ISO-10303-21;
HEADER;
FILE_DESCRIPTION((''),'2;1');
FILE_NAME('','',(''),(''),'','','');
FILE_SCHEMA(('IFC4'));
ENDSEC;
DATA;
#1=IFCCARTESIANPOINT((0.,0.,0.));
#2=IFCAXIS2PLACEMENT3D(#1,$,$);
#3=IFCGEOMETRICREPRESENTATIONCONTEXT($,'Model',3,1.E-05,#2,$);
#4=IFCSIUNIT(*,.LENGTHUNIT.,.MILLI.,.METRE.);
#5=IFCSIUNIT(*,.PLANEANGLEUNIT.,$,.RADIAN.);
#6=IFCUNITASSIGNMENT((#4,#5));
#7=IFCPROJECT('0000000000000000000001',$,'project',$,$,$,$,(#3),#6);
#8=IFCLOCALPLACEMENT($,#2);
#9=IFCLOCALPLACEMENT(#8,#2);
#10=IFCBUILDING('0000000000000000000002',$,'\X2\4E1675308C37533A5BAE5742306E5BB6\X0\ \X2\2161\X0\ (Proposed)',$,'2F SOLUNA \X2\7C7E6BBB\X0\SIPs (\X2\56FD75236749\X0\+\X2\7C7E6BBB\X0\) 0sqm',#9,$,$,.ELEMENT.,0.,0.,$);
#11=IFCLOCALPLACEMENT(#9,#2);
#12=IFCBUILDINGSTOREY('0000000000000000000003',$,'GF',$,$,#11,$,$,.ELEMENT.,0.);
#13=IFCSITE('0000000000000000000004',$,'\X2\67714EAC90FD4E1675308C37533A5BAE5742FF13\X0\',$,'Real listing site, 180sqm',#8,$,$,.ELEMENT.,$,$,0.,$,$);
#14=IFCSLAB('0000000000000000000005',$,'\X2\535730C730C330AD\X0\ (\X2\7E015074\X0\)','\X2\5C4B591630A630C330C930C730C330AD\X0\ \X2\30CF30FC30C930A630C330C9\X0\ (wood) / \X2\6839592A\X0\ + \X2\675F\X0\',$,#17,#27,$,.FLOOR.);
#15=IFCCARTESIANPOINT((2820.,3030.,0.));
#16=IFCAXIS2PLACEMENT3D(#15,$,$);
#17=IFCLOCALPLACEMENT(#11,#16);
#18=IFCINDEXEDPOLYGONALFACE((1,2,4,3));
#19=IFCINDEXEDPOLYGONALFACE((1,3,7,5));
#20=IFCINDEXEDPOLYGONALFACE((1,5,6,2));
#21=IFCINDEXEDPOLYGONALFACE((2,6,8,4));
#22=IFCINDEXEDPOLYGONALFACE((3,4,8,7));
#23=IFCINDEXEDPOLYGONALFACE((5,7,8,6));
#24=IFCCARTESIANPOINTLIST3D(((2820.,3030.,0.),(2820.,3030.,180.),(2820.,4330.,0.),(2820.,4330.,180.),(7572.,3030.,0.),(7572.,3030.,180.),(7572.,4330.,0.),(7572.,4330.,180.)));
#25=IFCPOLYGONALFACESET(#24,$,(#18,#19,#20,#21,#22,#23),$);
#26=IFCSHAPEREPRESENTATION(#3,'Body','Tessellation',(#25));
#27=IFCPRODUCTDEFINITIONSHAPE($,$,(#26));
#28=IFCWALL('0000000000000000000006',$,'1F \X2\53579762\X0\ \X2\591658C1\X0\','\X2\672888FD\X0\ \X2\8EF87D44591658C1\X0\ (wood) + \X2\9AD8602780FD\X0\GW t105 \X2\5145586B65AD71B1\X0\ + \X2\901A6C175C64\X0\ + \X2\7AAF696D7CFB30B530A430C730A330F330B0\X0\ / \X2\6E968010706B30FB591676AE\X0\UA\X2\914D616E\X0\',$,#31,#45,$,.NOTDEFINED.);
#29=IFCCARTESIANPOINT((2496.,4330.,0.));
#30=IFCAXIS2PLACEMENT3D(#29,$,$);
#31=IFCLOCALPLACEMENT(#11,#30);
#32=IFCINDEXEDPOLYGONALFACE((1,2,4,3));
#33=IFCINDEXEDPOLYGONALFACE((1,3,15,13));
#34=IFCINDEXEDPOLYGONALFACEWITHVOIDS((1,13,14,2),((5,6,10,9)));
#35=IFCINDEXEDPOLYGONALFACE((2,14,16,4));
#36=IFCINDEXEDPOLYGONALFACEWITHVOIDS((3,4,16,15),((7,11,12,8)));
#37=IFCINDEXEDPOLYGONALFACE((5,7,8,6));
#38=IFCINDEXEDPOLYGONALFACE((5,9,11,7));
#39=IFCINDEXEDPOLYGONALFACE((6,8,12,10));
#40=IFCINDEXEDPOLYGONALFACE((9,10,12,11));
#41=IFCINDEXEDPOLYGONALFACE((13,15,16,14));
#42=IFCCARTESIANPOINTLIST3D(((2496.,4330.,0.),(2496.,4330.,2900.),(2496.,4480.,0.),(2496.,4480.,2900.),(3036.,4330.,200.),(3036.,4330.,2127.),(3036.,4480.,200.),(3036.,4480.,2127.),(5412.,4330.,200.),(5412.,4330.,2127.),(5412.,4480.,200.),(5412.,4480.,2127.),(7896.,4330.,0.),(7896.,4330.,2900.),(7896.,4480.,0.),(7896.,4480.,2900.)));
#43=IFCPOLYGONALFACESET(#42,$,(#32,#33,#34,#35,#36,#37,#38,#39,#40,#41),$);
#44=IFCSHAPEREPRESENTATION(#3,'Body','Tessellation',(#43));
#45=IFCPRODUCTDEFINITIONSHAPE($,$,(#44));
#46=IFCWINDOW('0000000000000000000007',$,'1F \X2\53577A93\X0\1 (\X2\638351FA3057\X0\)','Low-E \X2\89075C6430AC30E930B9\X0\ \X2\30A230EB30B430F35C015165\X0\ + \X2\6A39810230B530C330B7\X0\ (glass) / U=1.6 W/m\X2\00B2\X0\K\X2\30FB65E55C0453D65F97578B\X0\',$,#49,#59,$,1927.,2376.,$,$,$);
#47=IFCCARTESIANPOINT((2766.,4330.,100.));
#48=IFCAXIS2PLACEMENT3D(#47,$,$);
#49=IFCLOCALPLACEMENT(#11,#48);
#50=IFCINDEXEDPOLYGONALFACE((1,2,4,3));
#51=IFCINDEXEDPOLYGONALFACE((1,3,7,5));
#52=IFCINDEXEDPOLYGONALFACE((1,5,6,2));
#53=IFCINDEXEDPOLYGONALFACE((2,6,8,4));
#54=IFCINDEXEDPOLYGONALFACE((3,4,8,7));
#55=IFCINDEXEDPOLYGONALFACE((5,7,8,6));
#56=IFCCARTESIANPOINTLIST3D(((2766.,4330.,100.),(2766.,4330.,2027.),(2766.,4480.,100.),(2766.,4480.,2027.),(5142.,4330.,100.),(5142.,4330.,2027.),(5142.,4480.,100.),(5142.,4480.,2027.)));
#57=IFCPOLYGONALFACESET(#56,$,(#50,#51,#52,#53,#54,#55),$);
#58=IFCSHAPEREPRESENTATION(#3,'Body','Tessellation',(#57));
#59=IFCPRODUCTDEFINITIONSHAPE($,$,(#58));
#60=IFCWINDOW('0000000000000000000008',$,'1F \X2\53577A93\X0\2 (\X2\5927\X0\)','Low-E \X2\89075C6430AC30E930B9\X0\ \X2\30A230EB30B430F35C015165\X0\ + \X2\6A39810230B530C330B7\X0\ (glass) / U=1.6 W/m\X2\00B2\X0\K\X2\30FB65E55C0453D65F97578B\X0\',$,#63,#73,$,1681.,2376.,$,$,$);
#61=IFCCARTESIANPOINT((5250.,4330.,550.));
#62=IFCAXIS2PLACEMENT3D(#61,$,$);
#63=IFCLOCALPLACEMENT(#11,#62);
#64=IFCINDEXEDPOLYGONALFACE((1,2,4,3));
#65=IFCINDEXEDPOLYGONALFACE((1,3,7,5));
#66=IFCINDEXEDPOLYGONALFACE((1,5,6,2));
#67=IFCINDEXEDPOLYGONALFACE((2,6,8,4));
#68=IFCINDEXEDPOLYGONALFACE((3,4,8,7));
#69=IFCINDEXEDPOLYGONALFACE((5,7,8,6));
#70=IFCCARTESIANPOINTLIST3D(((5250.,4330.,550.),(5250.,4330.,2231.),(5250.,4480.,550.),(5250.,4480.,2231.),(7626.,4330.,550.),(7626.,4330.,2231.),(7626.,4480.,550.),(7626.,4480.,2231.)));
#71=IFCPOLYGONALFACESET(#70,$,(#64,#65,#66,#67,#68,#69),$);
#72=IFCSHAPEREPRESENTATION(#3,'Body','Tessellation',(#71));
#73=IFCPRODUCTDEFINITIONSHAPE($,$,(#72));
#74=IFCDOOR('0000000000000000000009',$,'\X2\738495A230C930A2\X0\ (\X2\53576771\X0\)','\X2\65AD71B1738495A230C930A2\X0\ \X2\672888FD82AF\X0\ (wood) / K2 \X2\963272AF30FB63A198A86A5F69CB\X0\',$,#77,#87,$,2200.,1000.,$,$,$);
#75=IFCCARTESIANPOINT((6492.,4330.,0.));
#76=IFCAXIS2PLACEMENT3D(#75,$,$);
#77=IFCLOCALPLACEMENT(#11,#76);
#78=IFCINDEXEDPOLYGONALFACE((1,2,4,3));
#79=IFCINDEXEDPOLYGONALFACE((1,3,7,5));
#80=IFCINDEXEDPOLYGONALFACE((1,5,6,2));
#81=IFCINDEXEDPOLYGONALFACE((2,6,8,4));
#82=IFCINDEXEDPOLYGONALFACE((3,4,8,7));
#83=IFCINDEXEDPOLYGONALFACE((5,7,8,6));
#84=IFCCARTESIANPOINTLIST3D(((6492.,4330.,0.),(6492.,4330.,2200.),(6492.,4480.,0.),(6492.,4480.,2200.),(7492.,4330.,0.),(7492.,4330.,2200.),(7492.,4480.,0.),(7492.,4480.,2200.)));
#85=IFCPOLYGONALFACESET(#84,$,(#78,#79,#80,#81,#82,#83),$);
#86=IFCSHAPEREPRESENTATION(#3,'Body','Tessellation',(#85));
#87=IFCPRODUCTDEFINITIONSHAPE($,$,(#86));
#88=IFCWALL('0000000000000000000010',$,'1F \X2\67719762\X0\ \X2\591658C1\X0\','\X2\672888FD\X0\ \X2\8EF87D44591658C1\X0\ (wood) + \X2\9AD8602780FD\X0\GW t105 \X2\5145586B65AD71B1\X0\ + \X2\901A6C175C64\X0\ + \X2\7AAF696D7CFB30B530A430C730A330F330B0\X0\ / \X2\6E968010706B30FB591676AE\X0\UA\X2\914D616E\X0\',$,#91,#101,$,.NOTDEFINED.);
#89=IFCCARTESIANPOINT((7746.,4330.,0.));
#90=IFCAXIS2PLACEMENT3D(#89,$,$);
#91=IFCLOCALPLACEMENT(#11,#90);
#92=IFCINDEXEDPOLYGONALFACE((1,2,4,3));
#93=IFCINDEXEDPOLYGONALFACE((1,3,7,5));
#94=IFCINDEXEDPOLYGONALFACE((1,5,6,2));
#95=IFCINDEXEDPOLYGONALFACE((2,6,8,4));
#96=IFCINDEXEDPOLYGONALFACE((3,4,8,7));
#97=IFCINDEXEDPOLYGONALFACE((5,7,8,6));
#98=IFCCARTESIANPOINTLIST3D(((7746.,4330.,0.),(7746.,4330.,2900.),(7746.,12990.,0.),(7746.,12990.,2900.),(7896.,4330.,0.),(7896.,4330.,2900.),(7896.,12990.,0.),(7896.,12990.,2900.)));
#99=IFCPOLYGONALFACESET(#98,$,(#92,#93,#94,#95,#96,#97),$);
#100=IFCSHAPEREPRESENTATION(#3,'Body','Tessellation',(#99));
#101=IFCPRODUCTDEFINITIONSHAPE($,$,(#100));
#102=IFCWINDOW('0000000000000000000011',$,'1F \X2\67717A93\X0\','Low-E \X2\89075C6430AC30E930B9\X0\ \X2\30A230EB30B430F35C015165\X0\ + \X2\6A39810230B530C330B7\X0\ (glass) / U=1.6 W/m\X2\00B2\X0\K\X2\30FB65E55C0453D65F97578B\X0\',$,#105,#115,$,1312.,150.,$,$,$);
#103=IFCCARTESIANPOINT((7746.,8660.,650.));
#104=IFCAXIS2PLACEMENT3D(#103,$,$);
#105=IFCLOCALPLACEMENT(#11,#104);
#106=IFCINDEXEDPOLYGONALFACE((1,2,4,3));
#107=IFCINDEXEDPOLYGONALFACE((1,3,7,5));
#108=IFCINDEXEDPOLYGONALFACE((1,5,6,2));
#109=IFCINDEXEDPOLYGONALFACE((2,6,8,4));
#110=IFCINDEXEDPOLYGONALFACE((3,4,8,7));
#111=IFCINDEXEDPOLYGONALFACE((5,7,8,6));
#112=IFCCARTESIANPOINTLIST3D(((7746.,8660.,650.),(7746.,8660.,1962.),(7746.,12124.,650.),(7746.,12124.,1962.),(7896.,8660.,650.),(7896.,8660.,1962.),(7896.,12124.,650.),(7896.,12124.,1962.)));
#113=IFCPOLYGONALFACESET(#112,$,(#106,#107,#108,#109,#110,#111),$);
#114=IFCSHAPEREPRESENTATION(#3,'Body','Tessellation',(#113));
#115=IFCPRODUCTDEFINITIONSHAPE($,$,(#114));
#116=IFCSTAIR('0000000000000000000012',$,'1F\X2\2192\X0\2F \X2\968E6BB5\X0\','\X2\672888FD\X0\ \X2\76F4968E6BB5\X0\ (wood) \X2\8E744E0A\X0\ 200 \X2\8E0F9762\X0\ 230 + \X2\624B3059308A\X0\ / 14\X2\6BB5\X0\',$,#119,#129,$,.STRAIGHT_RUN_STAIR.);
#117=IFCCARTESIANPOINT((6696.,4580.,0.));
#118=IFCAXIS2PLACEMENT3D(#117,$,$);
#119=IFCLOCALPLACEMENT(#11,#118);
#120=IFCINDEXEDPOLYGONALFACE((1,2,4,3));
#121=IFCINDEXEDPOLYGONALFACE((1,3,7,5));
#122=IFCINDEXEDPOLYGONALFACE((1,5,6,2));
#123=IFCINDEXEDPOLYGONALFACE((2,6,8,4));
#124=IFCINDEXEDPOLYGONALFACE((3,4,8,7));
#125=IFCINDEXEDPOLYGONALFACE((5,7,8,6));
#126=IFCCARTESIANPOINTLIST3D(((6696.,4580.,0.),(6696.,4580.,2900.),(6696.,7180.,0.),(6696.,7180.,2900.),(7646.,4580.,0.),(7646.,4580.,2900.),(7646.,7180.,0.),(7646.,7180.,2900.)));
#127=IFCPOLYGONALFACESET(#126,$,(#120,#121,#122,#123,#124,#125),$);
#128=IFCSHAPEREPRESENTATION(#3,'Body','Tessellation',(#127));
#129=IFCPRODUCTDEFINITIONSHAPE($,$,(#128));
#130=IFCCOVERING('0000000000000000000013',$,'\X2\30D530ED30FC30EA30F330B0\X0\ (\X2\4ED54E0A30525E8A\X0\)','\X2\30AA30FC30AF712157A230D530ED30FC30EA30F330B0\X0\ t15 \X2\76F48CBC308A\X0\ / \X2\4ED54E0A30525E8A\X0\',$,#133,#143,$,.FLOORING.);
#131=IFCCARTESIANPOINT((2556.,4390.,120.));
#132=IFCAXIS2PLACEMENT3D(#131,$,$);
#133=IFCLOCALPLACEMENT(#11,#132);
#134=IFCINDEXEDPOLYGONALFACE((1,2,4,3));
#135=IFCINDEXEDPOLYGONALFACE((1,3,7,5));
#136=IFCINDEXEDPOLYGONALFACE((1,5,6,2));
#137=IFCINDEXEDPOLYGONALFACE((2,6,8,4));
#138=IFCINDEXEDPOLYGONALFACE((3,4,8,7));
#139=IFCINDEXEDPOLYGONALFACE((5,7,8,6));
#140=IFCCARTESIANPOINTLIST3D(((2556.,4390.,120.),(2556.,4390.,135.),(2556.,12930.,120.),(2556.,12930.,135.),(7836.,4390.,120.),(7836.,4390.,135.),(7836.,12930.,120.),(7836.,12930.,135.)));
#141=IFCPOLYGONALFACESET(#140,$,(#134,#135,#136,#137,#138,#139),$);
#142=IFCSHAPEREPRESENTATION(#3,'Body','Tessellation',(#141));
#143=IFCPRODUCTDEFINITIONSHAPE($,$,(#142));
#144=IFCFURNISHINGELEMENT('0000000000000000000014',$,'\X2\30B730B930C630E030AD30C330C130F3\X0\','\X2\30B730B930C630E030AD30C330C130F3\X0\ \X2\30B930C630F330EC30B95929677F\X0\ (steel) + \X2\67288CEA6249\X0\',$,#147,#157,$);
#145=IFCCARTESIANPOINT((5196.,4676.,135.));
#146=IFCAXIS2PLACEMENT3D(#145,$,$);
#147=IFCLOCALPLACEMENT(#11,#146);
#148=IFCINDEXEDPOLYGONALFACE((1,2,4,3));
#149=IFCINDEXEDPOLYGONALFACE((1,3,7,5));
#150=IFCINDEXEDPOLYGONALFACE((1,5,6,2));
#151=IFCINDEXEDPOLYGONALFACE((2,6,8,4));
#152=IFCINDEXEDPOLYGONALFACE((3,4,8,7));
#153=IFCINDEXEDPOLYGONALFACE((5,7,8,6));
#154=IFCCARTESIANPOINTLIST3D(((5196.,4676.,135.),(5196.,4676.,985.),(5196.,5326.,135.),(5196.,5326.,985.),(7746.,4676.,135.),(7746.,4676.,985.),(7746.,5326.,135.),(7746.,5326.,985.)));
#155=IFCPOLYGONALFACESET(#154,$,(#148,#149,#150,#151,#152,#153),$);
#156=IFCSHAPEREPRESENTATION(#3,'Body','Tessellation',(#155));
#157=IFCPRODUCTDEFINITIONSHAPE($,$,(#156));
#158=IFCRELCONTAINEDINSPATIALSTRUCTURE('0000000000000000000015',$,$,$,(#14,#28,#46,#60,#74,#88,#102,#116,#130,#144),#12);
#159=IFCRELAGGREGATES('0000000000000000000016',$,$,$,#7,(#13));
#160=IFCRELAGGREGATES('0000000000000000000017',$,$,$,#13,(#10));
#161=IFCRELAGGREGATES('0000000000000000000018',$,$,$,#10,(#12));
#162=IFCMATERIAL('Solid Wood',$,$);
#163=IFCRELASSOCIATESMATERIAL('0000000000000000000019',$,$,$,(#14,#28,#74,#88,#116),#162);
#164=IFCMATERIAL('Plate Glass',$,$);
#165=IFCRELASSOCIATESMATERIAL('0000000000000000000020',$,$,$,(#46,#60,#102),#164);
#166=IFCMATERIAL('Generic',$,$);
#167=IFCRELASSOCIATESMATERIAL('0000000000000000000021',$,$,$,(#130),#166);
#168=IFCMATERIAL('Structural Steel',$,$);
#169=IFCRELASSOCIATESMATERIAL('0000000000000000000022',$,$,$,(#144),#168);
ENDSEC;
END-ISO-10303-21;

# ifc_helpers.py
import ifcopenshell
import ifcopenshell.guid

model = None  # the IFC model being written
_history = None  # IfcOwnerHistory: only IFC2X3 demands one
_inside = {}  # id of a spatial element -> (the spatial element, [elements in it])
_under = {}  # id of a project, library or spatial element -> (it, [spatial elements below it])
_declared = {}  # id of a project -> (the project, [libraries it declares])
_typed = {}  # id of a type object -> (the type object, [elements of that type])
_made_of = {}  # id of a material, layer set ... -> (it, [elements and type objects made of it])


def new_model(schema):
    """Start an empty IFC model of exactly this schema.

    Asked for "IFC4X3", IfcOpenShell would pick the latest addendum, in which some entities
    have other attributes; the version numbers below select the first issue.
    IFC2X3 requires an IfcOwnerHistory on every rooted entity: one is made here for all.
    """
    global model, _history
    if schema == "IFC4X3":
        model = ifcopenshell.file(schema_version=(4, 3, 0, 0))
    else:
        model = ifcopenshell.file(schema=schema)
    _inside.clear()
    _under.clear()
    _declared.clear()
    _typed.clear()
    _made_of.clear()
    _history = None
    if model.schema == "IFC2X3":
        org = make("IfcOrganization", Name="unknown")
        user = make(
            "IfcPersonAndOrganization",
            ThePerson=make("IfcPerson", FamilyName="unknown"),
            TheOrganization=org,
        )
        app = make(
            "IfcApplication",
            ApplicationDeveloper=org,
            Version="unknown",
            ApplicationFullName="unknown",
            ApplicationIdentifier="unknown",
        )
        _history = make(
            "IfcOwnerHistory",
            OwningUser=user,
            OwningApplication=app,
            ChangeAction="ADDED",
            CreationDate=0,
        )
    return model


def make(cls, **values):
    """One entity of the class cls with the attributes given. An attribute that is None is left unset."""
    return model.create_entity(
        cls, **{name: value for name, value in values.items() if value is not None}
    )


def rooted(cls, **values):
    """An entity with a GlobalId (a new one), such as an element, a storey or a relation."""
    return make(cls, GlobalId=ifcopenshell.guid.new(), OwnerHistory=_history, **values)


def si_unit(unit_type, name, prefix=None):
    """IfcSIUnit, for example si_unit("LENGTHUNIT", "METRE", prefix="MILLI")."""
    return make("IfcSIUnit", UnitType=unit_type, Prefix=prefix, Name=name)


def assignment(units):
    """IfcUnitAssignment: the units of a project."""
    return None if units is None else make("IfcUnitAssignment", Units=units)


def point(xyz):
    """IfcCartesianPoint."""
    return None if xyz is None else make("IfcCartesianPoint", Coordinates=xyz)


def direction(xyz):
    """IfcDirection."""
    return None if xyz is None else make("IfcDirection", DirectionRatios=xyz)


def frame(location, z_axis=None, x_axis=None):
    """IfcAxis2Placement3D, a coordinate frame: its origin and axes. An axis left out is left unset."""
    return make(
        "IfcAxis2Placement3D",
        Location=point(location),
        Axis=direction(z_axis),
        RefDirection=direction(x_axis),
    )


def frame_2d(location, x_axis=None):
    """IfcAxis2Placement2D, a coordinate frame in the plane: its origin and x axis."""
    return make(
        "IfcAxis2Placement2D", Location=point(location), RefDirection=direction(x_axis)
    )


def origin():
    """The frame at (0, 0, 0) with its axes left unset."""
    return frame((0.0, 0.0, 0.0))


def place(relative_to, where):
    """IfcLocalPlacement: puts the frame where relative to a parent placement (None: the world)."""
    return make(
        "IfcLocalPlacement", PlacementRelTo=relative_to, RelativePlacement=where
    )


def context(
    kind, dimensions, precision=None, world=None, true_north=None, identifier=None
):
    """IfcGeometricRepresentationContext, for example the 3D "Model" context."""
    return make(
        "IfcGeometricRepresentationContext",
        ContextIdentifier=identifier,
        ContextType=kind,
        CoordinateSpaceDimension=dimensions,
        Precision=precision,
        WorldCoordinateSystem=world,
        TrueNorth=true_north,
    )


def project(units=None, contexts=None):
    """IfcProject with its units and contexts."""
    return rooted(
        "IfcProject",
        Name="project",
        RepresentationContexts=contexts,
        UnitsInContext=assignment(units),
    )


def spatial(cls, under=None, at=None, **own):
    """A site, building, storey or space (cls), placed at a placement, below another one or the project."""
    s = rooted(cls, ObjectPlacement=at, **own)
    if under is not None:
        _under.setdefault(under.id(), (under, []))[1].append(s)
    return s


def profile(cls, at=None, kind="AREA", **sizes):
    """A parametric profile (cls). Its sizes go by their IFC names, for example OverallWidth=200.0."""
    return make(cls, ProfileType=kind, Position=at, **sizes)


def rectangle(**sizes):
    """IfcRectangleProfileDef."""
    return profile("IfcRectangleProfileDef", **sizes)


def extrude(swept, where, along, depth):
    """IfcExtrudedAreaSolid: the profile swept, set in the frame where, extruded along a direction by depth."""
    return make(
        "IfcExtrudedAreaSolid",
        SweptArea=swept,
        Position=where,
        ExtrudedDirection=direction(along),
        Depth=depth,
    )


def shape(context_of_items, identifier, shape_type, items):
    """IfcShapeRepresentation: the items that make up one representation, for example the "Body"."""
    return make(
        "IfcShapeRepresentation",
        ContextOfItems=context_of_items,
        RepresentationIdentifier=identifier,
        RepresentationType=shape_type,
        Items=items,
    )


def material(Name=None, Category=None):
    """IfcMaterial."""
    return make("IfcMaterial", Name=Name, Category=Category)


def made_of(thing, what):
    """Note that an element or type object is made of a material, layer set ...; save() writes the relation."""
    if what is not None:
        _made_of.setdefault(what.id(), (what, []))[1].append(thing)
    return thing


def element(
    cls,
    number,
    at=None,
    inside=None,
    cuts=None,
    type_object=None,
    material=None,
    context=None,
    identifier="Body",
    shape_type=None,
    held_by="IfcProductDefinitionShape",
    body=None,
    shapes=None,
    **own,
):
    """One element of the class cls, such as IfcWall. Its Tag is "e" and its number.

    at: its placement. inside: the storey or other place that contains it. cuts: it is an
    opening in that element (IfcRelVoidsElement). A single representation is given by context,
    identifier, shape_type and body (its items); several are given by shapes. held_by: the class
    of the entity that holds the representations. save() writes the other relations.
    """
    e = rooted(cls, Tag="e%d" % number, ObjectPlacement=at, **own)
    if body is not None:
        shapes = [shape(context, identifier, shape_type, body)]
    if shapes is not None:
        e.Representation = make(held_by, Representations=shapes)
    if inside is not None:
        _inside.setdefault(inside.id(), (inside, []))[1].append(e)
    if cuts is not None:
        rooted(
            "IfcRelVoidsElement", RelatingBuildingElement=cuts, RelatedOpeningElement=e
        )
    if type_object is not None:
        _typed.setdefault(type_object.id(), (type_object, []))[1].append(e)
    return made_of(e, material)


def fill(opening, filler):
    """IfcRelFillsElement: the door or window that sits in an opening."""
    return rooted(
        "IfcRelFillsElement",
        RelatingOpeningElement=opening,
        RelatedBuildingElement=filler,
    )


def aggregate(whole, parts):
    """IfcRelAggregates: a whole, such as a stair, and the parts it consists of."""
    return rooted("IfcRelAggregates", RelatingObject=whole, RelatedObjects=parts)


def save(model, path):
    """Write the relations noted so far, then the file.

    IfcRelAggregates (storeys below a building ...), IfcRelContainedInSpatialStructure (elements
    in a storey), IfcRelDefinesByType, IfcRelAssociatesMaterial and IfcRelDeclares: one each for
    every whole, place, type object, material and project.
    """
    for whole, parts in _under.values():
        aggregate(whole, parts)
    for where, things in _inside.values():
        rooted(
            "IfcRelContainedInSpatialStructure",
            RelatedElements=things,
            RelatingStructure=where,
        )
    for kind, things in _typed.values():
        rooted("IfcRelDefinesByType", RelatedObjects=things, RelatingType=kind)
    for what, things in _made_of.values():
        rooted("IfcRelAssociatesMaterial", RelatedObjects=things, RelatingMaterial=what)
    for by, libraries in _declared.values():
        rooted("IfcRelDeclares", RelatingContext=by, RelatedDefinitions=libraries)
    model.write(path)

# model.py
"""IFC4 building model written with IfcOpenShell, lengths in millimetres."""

from ifc_helpers import new_model, si_unit, frame, frame_2d, origin, place, context, project, spatial, rectangle, extrude, material, element, fill, save


model = new_model("IFC4")

# Units and contexts
model_context = context("Model", 3, precision=1e-05, world=origin())
ifc_project = project(units=[si_unit("LENGTHUNIT", "METRE", prefix="MILLI"), si_unit("PLANEANGLEUNIT", "RADIAN")], contexts=[model_context])

# Site, building, storey
site_placement = place(None, origin())
site = spatial("IfcSite", under=ifc_project, at=site_placement, Name="東京都世田谷区宮坂３", ObjectType="Real listing site, 180sqm", CompositionType="ELEMENT", RefElevation=0.0)
building_placement = place(site_placement, origin())
building = spatial("IfcBuilding", under=site, at=building_placement, Name="世田谷区宮坂の家 Ⅱ (Proposed)", ObjectType="2F SOLUNA 籾殻SIPs (国産杉+籾殻) 0sqm", CompositionType="ELEMENT", ElevationOfRefHeight=0.0, ElevationOfTerrain=0.0)
storey_placement = place(building_placement, origin())
storey = spatial("IfcBuildingStorey", under=building, at=storey_placement, Name="GF", CompositionType="ELEMENT", Elevation=0.0)

# Slab
ifc_material_1 = material(Name="Solid Wood")
slab_1_placement = place(storey_placement, frame((2820.0, 3030.0, 0.0)))
element("IfcSlab", 1, at=slab_1_placement, inside=storey, material=ifc_material_1, Name="南デッキ (縁側)", Description="屋外ウッドデッキ ハードウッド (wood) / 根太 + 束", PredefinedType="FLOOR", context=model_context, shape_type="SweptSolid", body=[
    extrude(rectangle(XDim=4752.0, YDim=1300.0, at=frame_2d((2376.0, 650.0))), frame((2820.0, 3030.0, 0.0)), (0.0, 0.0, 1.0), 180.0),
])

# Wall, openings, windows, door
wall_1_placement = place(storey_placement, frame((2496.0, 4330.0, 0.0)))
wall_1 = element("IfcWall", 2, at=wall_1_placement, inside=storey, material=ifc_material_1, Name="1F 南面 外壁", Description="木製 軸組外壁 (wood) + 高性能GW t105 充填断熱 + 通気層 + 窯業系サイディング / 準耐火・外皮UA配慮", PredefinedType="NOTDEFINED", context=model_context, shape_type="SweptSolid", body=[
    extrude(rectangle(XDim=5400.0, YDim=150.0, at=frame_2d((2700.0, 75.0))), frame((2496.0, 4330.0, 0.0)), (0.0, 0.0, 1.0), 2900.0),
])
opening_1_placement = place(storey_placement, frame((2766.0, 4330.0, 100.0)))
opening_1 = element("IfcOpeningElement", 3, at=opening_1_placement, cuts=wall_1, PredefinedType="NOTDEFINED", context=model_context, shape_type="SweptSolid", body=[
    extrude(rectangle(XDim=2376.0, YDim=150.0, at=frame_2d((1188.0, 75.0))), frame((2766.0, 4330.0, 100.0)), (0.0, 0.0, 1.0), 1927.0),
])
opening_2_placement = place(storey_placement, frame((5250.0, 4330.0, 550.0)))
opening_2 = element("IfcOpeningElement", 4, at=opening_2_placement, cuts=wall_1, PredefinedType="NOTDEFINED", context=model_context, shape_type="SweptSolid", body=[
    extrude(rectangle(XDim=2376.0, YDim=150.0, at=frame_2d((1188.0, 75.0))), frame((5250.0, 4330.0, 550.0)), (0.0, 0.0, 1.0), 1681.0),
])
opening_3_placement = place(storey_placement, frame((6492.0, 4330.0, 0.0)))
opening_3 = element("IfcOpeningElement", 5, at=opening_3_placement, cuts=wall_1, PredefinedType="NOTDEFINED", context=model_context, shape_type="SweptSolid", body=[
    extrude(rectangle(XDim=1000.0, YDim=150.0, at=frame_2d((500.0, 75.0))), frame((6492.0, 4330.0, 0.0)), (0.0, 0.0, 1.0), 2200.0),
])
ifc_material_2 = material(Name="Plate Glass")
window_1_placement = place(storey_placement, frame((2766.0, 4330.0, 100.0)))
window_1 = element("IfcWindow", 6, at=window_1_placement, inside=storey, material=ifc_material_2, Name="1F 南窓1 (掃出し)", Description="Low-E 複層ガラス アルゴン封入 + 樹脂サッシ (glass) / U=1.6 W/m²K・日射取得型", OverallHeight=1927.0, OverallWidth=2376.0, context=model_context, shape_type="SweptSolid", body=[
    extrude(rectangle(XDim=2376.0, YDim=150.0, at=frame_2d((1188.0, 75.0))), frame((2766.0, 4330.0, 100.0)), (0.0, 0.0, 1.0), 1927.0),
])
fill(opening_1, window_1)
window_2_placement = place(storey_placement, frame((5250.0, 4330.0, 550.0)))
window_2 = element("IfcWindow", 7, at=window_2_placement, inside=storey, material=ifc_material_2, Name="1F 南窓2 (大)", Description="Low-E 複層ガラス アルゴン封入 + 樹脂サッシ (glass) / U=1.6 W/m²K・日射取得型", OverallHeight=1681.0, OverallWidth=2376.0, context=model_context, shape_type="SweptSolid", body=[
    extrude(rectangle(XDim=2376.0, YDim=150.0, at=frame_2d((1188.0, 75.0))), frame((5250.0, 4330.0, 550.0)), (0.0, 0.0, 1.0), 1681.0),
])
fill(opening_2, window_2)
door_placement = place(storey_placement, frame((6492.0, 4330.0, 0.0)))
door = element("IfcDoor", 8, at=door_placement, inside=storey, material=ifc_material_1, Name="玄関ドア (南東)", Description="断熱玄関ドア 木製芯 (wood) / K2 防犯・採風機構", OverallHeight=2200.0, OverallWidth=1000.0, context=model_context, shape_type="SweptSolid", body=[
    extrude(rectangle(XDim=1000.0, YDim=150.0, at=frame_2d((500.0, 75.0))), frame((6492.0, 4330.0, 0.0)), (0.0, 0.0, 1.0), 2200.0),
])
fill(opening_3, door)

# Wall, opening, window
wall_2_placement = place(storey_placement, frame((7746.0, 4330.0, 0.0)))
wall_2 = element("IfcWall", 9, at=wall_2_placement, inside=storey, material=ifc_material_1, Name="1F 東面 外壁", Description="木製 軸組外壁 (wood) + 高性能GW t105 充填断熱 + 通気層 + 窯業系サイディング / 準耐火・外皮UA配慮", PredefinedType="NOTDEFINED", context=model_context, shape_type="SweptSolid", body=[
    extrude(rectangle(XDim=150.0, YDim=8660.0, at=frame_2d((75.0, 4330.0))), frame((7746.0, 4330.0, 0.0)), (0.0, 0.0, 1.0), 2900.0),
])
opening_4_placement = place(storey_placement, frame((7746.0, 8660.0, 650.0)))
opening_4 = element("IfcOpeningElement", 10, at=opening_4_placement, cuts=wall_2, PredefinedType="NOTDEFINED", context=model_context, shape_type="SweptSolid", body=[
    extrude(rectangle(XDim=150.0, YDim=3464.0, at=frame_2d((75.0, 1732.0))), frame((7746.0, 8660.0, 650.0)), (0.0, 0.0, 1.0), 1312.0),
])
window_3_placement = place(storey_placement, frame((7746.0, 8660.0, 650.0)))
window_3 = element("IfcWindow", 11, at=window_3_placement, inside=storey, material=ifc_material_2, Name="1F 東窓", Description="Low-E 複層ガラス アルゴン封入 + 樹脂サッシ (glass) / U=1.6 W/m²K・日射取得型", OverallHeight=1312.0, OverallWidth=150.0, context=model_context, shape_type="SweptSolid", body=[
    extrude(rectangle(XDim=150.0, YDim=3464.0, at=frame_2d((75.0, 1732.0))), frame((7746.0, 8660.0, 650.0)), (0.0, 0.0, 1.0), 1312.0),
])
fill(opening_4, window_3)

# Stair
stair_placement = place(storey_placement, frame((6696.0, 4580.0, 0.0)))
element("IfcStair", 12, at=stair_placement, inside=storey, material=ifc_material_1, Name="1F→2F 階段", Description="木製 直階段 (wood) 蹴上 200 踏面 230 + 手すり / 14段", PredefinedType="STRAIGHT_RUN_STAIR", context=model_context, shape_type="SweptSolid", body=[
    extrude(rectangle(XDim=950.0, YDim=2600.0, at=frame_2d((475.0, 1300.0))), frame((6696.0, 4580.0, 0.0)), (0.0, 0.0, 1.0), 2900.0),
])

# Covering
ifc_material_3 = material(Name="Generic")
covering_placement = place(storey_placement, frame((2556.0, 4390.0, 120.0)))
element("IfcCovering", 13, at=covering_placement, inside=storey, material=ifc_material_3, Name="フローリング (仕上げ床)", Description="オーク無垢フローリング t15 直貼り / 仕上げ床", PredefinedType="FLOORING", context=model_context, shape_type="SweptSolid", body=[
    extrude(rectangle(XDim=5280.0, YDim=8540.0, at=frame_2d((2640.0, 4270.0))), frame((2556.0, 4390.0, 120.0)), (0.0, 0.0, 1.0), 15.0),
])

# Furnishing element
ifc_material_4 = material(Name="Structural Steel")
furnishing_placement = place(storey_placement, frame((5196.0, 4676.0, 135.0)))
element("IfcFurnishingElement", 14, at=furnishing_placement, inside=storey, material=ifc_material_4, Name="システムキッチン", Description="システムキッチン ステンレス天板 (steel) + 木質扉", context=model_context, shape_type="SweptSolid", body=[
    extrude(rectangle(XDim=2550.0, YDim=650.0, at=frame_2d((1275.0, 325.0))), frame((5196.0, 4676.0, 135.0)), (0.0, 0.0, 1.0), 850.0),
])

save(model, "model.ifc")
